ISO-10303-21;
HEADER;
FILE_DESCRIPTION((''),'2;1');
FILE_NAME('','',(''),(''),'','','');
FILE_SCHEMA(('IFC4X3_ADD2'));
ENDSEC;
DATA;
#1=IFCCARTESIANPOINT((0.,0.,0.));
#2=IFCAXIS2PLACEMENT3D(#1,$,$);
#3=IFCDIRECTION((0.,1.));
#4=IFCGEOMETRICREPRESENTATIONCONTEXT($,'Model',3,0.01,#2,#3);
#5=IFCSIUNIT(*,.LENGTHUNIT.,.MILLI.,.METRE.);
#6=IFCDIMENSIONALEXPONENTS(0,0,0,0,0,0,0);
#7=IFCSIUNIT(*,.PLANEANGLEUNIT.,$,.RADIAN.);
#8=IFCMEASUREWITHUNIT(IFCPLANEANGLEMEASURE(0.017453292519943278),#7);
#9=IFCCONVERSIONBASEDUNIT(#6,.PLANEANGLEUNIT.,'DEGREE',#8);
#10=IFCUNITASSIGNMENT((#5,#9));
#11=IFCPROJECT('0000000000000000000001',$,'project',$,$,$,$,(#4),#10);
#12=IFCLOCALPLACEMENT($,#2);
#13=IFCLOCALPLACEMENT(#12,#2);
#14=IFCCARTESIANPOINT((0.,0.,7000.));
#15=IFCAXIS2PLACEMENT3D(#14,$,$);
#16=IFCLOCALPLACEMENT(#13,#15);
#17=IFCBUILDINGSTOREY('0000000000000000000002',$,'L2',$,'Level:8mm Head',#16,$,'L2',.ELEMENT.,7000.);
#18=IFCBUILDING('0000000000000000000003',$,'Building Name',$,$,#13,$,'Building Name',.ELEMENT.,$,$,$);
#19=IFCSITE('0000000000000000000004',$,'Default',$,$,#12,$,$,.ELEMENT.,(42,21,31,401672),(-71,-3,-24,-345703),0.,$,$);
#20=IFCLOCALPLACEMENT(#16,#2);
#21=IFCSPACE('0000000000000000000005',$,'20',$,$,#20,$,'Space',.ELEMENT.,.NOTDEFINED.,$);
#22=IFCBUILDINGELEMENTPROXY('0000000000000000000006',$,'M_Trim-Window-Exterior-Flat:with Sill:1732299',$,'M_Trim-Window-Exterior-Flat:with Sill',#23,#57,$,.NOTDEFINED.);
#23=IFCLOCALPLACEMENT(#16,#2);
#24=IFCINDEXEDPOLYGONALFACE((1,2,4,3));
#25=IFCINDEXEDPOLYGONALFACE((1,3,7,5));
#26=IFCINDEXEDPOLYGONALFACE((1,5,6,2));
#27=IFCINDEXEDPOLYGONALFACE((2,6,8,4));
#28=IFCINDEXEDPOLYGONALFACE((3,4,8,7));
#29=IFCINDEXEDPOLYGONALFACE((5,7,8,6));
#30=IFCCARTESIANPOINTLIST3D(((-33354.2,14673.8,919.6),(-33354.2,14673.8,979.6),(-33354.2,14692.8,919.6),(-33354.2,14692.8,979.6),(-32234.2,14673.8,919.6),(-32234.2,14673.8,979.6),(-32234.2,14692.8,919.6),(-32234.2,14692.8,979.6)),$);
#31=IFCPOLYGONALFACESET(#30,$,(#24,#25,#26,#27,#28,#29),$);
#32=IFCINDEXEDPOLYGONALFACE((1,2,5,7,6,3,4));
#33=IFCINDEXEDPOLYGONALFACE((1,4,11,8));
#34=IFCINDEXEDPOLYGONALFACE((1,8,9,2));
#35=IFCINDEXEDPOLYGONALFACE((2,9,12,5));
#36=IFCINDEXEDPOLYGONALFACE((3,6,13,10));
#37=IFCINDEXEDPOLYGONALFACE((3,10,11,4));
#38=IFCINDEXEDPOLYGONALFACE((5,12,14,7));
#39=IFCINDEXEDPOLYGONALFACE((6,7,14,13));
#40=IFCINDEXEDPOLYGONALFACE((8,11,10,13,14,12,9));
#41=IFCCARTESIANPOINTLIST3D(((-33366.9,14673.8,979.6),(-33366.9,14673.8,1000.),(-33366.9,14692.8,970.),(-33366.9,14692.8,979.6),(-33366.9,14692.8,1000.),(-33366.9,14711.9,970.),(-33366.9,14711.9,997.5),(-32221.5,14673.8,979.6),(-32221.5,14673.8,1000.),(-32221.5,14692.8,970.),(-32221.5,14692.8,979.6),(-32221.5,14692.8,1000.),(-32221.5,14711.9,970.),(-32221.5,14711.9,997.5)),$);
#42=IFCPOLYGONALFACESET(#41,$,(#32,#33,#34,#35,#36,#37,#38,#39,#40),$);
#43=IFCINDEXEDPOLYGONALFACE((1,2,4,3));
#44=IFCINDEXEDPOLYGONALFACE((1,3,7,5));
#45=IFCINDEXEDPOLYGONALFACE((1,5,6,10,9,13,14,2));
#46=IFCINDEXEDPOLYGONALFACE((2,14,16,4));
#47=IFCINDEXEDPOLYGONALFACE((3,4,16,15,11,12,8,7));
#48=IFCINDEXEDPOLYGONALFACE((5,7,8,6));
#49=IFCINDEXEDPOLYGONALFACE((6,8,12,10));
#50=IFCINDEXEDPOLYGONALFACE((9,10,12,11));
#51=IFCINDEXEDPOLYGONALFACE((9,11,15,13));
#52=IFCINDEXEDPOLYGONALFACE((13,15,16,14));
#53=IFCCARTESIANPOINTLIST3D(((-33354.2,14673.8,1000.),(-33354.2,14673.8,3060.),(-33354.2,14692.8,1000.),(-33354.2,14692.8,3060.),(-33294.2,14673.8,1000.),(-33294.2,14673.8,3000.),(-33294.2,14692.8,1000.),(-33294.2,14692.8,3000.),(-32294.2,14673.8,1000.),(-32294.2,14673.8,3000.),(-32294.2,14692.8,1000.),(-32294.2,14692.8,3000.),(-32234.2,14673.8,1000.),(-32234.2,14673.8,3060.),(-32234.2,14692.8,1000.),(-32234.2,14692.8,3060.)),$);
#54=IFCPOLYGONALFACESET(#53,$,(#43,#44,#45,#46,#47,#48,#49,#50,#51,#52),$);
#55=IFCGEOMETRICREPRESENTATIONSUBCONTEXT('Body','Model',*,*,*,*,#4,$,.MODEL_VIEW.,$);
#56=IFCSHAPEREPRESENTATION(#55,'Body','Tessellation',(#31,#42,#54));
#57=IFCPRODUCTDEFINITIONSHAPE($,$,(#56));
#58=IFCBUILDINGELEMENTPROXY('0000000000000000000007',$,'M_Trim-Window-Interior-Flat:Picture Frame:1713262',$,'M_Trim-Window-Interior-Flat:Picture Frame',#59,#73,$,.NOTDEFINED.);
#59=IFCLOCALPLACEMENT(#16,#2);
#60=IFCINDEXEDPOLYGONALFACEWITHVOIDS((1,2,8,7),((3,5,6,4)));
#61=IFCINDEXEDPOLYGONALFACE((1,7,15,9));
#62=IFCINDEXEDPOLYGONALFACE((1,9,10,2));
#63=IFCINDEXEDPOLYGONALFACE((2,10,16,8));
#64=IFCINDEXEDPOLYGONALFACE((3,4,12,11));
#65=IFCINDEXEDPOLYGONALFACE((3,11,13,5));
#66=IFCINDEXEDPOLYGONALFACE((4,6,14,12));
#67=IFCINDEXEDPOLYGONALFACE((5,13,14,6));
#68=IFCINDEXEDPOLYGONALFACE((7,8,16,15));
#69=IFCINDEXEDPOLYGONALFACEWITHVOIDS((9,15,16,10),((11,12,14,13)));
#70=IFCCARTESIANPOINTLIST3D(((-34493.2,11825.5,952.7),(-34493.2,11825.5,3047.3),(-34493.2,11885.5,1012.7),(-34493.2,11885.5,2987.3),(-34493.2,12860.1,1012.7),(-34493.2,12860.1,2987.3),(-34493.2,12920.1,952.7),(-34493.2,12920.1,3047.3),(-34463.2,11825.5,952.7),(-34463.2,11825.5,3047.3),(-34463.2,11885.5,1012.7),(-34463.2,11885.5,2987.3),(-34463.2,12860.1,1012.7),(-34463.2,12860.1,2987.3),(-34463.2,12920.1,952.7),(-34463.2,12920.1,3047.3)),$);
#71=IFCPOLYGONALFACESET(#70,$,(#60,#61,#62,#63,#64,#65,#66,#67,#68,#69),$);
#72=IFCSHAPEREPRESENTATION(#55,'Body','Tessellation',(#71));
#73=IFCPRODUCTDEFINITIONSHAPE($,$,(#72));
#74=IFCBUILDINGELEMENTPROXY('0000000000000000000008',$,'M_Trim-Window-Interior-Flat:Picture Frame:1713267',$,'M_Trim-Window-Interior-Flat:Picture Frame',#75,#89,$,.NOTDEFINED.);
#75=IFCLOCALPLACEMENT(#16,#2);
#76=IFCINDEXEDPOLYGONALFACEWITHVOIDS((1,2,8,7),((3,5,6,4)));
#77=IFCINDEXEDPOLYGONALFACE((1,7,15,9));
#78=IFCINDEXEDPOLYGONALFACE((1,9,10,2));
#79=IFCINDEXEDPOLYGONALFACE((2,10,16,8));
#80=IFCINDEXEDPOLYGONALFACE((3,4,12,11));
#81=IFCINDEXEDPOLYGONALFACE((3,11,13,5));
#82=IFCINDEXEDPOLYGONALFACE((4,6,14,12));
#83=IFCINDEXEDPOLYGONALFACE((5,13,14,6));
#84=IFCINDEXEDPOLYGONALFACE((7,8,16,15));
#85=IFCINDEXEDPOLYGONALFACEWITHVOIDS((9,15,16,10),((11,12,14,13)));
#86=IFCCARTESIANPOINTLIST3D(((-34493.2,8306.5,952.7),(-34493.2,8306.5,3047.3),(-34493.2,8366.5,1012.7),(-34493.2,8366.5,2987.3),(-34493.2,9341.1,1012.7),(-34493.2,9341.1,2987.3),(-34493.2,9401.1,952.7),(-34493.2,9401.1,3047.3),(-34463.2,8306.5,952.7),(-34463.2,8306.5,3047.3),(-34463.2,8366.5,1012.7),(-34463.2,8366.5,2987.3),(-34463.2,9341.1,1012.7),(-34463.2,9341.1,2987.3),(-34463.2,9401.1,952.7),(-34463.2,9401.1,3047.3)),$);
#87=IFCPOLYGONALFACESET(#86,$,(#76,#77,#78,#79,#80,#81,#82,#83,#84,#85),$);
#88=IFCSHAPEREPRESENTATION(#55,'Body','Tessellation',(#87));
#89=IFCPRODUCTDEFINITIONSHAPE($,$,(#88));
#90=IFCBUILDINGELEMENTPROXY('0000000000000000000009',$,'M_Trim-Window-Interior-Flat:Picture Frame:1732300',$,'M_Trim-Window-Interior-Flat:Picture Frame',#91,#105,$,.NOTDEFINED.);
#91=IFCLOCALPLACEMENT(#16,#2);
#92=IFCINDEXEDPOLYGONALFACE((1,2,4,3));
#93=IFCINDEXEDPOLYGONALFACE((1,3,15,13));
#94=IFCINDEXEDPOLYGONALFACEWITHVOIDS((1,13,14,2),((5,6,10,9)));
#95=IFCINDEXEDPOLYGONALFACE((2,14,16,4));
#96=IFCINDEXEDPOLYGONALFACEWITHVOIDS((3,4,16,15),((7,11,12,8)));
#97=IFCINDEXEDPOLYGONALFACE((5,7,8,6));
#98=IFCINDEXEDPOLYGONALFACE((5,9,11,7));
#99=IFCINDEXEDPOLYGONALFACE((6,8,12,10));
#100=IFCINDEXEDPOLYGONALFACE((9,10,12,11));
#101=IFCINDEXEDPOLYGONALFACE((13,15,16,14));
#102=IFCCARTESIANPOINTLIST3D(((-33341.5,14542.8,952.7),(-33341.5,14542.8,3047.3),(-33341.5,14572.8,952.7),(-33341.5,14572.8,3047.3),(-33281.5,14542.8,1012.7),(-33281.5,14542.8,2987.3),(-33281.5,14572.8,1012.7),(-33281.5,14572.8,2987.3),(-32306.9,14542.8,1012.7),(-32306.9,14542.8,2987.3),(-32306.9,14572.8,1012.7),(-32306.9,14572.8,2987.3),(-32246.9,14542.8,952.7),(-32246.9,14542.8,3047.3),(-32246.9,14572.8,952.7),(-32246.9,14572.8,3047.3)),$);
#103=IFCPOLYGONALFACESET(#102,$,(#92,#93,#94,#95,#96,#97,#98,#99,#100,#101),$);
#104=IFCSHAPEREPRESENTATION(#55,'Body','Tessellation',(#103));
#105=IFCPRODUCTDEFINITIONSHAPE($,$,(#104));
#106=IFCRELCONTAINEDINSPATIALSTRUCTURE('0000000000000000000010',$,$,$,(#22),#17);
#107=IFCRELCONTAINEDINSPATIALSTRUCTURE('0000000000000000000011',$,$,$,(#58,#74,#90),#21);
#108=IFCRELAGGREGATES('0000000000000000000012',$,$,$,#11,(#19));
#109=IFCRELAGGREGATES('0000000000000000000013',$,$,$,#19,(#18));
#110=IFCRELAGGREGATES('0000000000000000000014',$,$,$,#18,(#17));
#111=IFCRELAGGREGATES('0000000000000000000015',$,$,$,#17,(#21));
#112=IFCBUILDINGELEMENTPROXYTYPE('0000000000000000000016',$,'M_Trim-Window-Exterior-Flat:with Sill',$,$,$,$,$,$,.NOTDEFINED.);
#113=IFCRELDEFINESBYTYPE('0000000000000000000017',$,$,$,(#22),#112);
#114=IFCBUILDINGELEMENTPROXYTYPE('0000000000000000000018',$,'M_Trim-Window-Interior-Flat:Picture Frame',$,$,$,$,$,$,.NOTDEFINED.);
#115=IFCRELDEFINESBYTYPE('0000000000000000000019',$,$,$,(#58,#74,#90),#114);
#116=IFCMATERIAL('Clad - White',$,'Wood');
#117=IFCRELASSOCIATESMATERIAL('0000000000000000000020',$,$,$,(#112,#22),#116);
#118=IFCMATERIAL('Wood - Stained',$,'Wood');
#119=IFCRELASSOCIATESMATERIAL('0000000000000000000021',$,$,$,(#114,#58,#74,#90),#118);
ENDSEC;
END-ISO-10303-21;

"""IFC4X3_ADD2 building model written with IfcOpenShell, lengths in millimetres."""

from ifc_helpers import new_model, entity, si_unit, converted_unit, direction, frame, frame_2d, origin, place, context, subcontext, project, spatial, polyline, rectangle, outline, extrude, source, transform, mapped, material, type_object, type_shapes, element, save


model = new_model("IFC4X3_ADD2")

# Units and contexts
model_context = context("Model", 3, precision=0.01, world=origin(), true_north=direction((0.0, 1.0)))
body_context = subcontext(model_context, "Body", "Model", "MODEL_VIEW")
ifc_project = project(units=[si_unit("LENGTHUNIT", "METRE", prefix="MILLI"), converted_unit("PLANEANGLEUNIT", "DEGREE", entity("IfcPlaneAngleMeasure", 0.017453292519943278), si_unit("PLANEANGLEUNIT", "RADIAN"), dimensions=[0, 0, 0, 0, 0, 0, 0])], contexts=[model_context])

# Site, building, storey
site_placement = place(None, origin())
site = spatial("IfcSite", under=ifc_project, at=site_placement, Name="Default", CompositionType="ELEMENT", RefLatitude=(42, 21, 31, 401672), RefLongitude=(-71, -3, -24, -345703), RefElevation=0.0)
building_placement = place(site_placement, origin())
building = spatial("IfcBuilding", under=site, at=building_placement, Name="Building Name", LongName="Building Name", CompositionType="ELEMENT")
storey_placement = place(building_placement, frame((0.0, 0.0, 7000.0)))
storey = spatial("IfcBuildingStorey", under=building, at=storey_placement, Name="L2", ObjectType="Level:8mm Head", LongName="L2", CompositionType="ELEMENT", Elevation=7000.0)

# Building element proxy
ifc_material_1 = material(Name="Clad - White", Category="Wood")
ifc_material_2 = material(Name="Wood - Stained", Category="Wood")
building_element_proxy_type_1 = type_object("IfcBuildingElementProxyType", Name="M_Trim-Window-Exterior-Flat:with Sill", PredefinedType="NOTDEFINED", material=ifc_material_1)
shared_shape_1 = source(origin(), body_context, "Body", "SweptSolid", [
    extrude(rectangle(XDim=1120.0, YDim=60.0, at=frame_2d((0.0, 0.0), x_axis=(1.0, 0.0))), frame((0.0, -2050.4, 0.0), z_axis=(0.0, 0.0, 1.0), x_axis=(-1.0, 0.0, 0.0)), (0.0, 0.0, 1.0), 19.0),
    extrude(outline(polyline([(-19.0, -15.2), (0.0, -15.2), (0.0, -5.7), (19.0, -5.7), (19.0, 14.8), (0.0, 14.8), (-19.0, 12.3), (-19.0, -15.2)])), frame((-572.7, -2014.8, 19.0), z_axis=(1.0, 0.0, 0.0), x_axis=(0.0, 0.0, -1.0)), (0.0, 0.0, 1.0), 1145.4),
    extrude(outline(polyline([(-1045.0, -560.0), (1015.0, -560.0), (1015.0, -500.0), (-985.0, -500.0), (-985.0, 500.0), (1015.0, 500.0), (1015.0, 560.0), (-1045.0, 560.0), (-1045.0, -560.0)])), frame((0.0, -985.0, 0.0), z_axis=(0.0, 0.0, 1.0), x_axis=(0.0, -1.0, 0.0)), (0.0, 0.0, 1.0), 19.0),
])
type_shapes(building_element_proxy_type_1, [shared_shape_1])
for number, where, z_axis, x_axis, name in (
    (1, (-32794.2, 14673.8, 3000.0), (0.0, 1.0, 0.0), (-1.0, 0.0, 0.0), "M_Trim-Window-Exterior-Flat:with Sill:1732299"),
):
    element("IfcBuildingElementProxy", number, at=place(storey_placement, frame(where, z_axis=z_axis, x_axis=x_axis)), inside=storey, type_object=building_element_proxy_type_1, material=ifc_material_1, Name=name, ObjectType="M_Trim-Window-Exterior-Flat:with Sill", PredefinedType="NOTDEFINED", context=body_context, shape_type="MappedRepresentation", body=[
        mapped(shared_shape_1, transform((0.0, 0.0, 0.0), scale=1.0)),
    ])

# Shared definitions
space_placement = place(storey_placement, origin())
space = spatial("IfcSpace", under=storey, at=space_placement, Name="20", LongName="Space", CompositionType="ELEMENT", PredefinedType="NOTDEFINED")

# Building element proxies
building_element_proxy_type_2 = type_object("IfcBuildingElementProxyType", Name="M_Trim-Window-Interior-Flat:Picture Frame", PredefinedType="NOTDEFINED", material=ifc_material_2)
shared_shape_2 = source(origin(), body_context, "Body", "SweptSolid", [
    extrude(outline(polyline([(-547.3, -1047.3), (547.3, -1047.3), (547.3, 1047.3), (-547.3, 1047.3), (-547.3, -1047.3)]), holes=[polyline([(-487.3, -987.3), (-487.3, 987.3), (487.3, 987.3), (487.3, -987.3), (-487.3, -987.3)])]), frame((0.0, -1000.0, 0.0), z_axis=(0.0, 0.0, 1.0), x_axis=(-1.0, 0.0, 0.0)), (0.0, 0.0, 1.0), 30.0),
])
type_shapes(building_element_proxy_type_2, [shared_shape_2])
for number, where, z_axis, x_axis, name in (
    (2, (-34493.2, 12372.8, 3000.0), (1.0, 0.0, 0.0), (0.0, 1.0, 0.0), "M_Trim-Window-Interior-Flat:Picture Frame:1713262"),
    (3, (-34493.2, 8853.8, 3000.0), (1.0, 0.0, 0.0), (0.0, 1.0, 0.0), "M_Trim-Window-Interior-Flat:Picture Frame:1713267"),
    (4, (-32794.2, 14572.8, 3000.0), (0.0, -1.0, 0.0), (1.0, 0.0, 0.0), "M_Trim-Window-Interior-Flat:Picture Frame:1732300"),
):
    element("IfcBuildingElementProxy", number, at=place(space_placement, frame(where, z_axis=z_axis, x_axis=x_axis)), inside=space, type_object=building_element_proxy_type_2, material=ifc_material_2, Name=name, ObjectType="M_Trim-Window-Interior-Flat:Picture Frame", PredefinedType="NOTDEFINED", context=body_context, shape_type="MappedRepresentation", body=[
        mapped(shared_shape_2, transform((0.0, 0.0, 0.0), scale=1.0)),
    ])

save(model, "model.ifc")
